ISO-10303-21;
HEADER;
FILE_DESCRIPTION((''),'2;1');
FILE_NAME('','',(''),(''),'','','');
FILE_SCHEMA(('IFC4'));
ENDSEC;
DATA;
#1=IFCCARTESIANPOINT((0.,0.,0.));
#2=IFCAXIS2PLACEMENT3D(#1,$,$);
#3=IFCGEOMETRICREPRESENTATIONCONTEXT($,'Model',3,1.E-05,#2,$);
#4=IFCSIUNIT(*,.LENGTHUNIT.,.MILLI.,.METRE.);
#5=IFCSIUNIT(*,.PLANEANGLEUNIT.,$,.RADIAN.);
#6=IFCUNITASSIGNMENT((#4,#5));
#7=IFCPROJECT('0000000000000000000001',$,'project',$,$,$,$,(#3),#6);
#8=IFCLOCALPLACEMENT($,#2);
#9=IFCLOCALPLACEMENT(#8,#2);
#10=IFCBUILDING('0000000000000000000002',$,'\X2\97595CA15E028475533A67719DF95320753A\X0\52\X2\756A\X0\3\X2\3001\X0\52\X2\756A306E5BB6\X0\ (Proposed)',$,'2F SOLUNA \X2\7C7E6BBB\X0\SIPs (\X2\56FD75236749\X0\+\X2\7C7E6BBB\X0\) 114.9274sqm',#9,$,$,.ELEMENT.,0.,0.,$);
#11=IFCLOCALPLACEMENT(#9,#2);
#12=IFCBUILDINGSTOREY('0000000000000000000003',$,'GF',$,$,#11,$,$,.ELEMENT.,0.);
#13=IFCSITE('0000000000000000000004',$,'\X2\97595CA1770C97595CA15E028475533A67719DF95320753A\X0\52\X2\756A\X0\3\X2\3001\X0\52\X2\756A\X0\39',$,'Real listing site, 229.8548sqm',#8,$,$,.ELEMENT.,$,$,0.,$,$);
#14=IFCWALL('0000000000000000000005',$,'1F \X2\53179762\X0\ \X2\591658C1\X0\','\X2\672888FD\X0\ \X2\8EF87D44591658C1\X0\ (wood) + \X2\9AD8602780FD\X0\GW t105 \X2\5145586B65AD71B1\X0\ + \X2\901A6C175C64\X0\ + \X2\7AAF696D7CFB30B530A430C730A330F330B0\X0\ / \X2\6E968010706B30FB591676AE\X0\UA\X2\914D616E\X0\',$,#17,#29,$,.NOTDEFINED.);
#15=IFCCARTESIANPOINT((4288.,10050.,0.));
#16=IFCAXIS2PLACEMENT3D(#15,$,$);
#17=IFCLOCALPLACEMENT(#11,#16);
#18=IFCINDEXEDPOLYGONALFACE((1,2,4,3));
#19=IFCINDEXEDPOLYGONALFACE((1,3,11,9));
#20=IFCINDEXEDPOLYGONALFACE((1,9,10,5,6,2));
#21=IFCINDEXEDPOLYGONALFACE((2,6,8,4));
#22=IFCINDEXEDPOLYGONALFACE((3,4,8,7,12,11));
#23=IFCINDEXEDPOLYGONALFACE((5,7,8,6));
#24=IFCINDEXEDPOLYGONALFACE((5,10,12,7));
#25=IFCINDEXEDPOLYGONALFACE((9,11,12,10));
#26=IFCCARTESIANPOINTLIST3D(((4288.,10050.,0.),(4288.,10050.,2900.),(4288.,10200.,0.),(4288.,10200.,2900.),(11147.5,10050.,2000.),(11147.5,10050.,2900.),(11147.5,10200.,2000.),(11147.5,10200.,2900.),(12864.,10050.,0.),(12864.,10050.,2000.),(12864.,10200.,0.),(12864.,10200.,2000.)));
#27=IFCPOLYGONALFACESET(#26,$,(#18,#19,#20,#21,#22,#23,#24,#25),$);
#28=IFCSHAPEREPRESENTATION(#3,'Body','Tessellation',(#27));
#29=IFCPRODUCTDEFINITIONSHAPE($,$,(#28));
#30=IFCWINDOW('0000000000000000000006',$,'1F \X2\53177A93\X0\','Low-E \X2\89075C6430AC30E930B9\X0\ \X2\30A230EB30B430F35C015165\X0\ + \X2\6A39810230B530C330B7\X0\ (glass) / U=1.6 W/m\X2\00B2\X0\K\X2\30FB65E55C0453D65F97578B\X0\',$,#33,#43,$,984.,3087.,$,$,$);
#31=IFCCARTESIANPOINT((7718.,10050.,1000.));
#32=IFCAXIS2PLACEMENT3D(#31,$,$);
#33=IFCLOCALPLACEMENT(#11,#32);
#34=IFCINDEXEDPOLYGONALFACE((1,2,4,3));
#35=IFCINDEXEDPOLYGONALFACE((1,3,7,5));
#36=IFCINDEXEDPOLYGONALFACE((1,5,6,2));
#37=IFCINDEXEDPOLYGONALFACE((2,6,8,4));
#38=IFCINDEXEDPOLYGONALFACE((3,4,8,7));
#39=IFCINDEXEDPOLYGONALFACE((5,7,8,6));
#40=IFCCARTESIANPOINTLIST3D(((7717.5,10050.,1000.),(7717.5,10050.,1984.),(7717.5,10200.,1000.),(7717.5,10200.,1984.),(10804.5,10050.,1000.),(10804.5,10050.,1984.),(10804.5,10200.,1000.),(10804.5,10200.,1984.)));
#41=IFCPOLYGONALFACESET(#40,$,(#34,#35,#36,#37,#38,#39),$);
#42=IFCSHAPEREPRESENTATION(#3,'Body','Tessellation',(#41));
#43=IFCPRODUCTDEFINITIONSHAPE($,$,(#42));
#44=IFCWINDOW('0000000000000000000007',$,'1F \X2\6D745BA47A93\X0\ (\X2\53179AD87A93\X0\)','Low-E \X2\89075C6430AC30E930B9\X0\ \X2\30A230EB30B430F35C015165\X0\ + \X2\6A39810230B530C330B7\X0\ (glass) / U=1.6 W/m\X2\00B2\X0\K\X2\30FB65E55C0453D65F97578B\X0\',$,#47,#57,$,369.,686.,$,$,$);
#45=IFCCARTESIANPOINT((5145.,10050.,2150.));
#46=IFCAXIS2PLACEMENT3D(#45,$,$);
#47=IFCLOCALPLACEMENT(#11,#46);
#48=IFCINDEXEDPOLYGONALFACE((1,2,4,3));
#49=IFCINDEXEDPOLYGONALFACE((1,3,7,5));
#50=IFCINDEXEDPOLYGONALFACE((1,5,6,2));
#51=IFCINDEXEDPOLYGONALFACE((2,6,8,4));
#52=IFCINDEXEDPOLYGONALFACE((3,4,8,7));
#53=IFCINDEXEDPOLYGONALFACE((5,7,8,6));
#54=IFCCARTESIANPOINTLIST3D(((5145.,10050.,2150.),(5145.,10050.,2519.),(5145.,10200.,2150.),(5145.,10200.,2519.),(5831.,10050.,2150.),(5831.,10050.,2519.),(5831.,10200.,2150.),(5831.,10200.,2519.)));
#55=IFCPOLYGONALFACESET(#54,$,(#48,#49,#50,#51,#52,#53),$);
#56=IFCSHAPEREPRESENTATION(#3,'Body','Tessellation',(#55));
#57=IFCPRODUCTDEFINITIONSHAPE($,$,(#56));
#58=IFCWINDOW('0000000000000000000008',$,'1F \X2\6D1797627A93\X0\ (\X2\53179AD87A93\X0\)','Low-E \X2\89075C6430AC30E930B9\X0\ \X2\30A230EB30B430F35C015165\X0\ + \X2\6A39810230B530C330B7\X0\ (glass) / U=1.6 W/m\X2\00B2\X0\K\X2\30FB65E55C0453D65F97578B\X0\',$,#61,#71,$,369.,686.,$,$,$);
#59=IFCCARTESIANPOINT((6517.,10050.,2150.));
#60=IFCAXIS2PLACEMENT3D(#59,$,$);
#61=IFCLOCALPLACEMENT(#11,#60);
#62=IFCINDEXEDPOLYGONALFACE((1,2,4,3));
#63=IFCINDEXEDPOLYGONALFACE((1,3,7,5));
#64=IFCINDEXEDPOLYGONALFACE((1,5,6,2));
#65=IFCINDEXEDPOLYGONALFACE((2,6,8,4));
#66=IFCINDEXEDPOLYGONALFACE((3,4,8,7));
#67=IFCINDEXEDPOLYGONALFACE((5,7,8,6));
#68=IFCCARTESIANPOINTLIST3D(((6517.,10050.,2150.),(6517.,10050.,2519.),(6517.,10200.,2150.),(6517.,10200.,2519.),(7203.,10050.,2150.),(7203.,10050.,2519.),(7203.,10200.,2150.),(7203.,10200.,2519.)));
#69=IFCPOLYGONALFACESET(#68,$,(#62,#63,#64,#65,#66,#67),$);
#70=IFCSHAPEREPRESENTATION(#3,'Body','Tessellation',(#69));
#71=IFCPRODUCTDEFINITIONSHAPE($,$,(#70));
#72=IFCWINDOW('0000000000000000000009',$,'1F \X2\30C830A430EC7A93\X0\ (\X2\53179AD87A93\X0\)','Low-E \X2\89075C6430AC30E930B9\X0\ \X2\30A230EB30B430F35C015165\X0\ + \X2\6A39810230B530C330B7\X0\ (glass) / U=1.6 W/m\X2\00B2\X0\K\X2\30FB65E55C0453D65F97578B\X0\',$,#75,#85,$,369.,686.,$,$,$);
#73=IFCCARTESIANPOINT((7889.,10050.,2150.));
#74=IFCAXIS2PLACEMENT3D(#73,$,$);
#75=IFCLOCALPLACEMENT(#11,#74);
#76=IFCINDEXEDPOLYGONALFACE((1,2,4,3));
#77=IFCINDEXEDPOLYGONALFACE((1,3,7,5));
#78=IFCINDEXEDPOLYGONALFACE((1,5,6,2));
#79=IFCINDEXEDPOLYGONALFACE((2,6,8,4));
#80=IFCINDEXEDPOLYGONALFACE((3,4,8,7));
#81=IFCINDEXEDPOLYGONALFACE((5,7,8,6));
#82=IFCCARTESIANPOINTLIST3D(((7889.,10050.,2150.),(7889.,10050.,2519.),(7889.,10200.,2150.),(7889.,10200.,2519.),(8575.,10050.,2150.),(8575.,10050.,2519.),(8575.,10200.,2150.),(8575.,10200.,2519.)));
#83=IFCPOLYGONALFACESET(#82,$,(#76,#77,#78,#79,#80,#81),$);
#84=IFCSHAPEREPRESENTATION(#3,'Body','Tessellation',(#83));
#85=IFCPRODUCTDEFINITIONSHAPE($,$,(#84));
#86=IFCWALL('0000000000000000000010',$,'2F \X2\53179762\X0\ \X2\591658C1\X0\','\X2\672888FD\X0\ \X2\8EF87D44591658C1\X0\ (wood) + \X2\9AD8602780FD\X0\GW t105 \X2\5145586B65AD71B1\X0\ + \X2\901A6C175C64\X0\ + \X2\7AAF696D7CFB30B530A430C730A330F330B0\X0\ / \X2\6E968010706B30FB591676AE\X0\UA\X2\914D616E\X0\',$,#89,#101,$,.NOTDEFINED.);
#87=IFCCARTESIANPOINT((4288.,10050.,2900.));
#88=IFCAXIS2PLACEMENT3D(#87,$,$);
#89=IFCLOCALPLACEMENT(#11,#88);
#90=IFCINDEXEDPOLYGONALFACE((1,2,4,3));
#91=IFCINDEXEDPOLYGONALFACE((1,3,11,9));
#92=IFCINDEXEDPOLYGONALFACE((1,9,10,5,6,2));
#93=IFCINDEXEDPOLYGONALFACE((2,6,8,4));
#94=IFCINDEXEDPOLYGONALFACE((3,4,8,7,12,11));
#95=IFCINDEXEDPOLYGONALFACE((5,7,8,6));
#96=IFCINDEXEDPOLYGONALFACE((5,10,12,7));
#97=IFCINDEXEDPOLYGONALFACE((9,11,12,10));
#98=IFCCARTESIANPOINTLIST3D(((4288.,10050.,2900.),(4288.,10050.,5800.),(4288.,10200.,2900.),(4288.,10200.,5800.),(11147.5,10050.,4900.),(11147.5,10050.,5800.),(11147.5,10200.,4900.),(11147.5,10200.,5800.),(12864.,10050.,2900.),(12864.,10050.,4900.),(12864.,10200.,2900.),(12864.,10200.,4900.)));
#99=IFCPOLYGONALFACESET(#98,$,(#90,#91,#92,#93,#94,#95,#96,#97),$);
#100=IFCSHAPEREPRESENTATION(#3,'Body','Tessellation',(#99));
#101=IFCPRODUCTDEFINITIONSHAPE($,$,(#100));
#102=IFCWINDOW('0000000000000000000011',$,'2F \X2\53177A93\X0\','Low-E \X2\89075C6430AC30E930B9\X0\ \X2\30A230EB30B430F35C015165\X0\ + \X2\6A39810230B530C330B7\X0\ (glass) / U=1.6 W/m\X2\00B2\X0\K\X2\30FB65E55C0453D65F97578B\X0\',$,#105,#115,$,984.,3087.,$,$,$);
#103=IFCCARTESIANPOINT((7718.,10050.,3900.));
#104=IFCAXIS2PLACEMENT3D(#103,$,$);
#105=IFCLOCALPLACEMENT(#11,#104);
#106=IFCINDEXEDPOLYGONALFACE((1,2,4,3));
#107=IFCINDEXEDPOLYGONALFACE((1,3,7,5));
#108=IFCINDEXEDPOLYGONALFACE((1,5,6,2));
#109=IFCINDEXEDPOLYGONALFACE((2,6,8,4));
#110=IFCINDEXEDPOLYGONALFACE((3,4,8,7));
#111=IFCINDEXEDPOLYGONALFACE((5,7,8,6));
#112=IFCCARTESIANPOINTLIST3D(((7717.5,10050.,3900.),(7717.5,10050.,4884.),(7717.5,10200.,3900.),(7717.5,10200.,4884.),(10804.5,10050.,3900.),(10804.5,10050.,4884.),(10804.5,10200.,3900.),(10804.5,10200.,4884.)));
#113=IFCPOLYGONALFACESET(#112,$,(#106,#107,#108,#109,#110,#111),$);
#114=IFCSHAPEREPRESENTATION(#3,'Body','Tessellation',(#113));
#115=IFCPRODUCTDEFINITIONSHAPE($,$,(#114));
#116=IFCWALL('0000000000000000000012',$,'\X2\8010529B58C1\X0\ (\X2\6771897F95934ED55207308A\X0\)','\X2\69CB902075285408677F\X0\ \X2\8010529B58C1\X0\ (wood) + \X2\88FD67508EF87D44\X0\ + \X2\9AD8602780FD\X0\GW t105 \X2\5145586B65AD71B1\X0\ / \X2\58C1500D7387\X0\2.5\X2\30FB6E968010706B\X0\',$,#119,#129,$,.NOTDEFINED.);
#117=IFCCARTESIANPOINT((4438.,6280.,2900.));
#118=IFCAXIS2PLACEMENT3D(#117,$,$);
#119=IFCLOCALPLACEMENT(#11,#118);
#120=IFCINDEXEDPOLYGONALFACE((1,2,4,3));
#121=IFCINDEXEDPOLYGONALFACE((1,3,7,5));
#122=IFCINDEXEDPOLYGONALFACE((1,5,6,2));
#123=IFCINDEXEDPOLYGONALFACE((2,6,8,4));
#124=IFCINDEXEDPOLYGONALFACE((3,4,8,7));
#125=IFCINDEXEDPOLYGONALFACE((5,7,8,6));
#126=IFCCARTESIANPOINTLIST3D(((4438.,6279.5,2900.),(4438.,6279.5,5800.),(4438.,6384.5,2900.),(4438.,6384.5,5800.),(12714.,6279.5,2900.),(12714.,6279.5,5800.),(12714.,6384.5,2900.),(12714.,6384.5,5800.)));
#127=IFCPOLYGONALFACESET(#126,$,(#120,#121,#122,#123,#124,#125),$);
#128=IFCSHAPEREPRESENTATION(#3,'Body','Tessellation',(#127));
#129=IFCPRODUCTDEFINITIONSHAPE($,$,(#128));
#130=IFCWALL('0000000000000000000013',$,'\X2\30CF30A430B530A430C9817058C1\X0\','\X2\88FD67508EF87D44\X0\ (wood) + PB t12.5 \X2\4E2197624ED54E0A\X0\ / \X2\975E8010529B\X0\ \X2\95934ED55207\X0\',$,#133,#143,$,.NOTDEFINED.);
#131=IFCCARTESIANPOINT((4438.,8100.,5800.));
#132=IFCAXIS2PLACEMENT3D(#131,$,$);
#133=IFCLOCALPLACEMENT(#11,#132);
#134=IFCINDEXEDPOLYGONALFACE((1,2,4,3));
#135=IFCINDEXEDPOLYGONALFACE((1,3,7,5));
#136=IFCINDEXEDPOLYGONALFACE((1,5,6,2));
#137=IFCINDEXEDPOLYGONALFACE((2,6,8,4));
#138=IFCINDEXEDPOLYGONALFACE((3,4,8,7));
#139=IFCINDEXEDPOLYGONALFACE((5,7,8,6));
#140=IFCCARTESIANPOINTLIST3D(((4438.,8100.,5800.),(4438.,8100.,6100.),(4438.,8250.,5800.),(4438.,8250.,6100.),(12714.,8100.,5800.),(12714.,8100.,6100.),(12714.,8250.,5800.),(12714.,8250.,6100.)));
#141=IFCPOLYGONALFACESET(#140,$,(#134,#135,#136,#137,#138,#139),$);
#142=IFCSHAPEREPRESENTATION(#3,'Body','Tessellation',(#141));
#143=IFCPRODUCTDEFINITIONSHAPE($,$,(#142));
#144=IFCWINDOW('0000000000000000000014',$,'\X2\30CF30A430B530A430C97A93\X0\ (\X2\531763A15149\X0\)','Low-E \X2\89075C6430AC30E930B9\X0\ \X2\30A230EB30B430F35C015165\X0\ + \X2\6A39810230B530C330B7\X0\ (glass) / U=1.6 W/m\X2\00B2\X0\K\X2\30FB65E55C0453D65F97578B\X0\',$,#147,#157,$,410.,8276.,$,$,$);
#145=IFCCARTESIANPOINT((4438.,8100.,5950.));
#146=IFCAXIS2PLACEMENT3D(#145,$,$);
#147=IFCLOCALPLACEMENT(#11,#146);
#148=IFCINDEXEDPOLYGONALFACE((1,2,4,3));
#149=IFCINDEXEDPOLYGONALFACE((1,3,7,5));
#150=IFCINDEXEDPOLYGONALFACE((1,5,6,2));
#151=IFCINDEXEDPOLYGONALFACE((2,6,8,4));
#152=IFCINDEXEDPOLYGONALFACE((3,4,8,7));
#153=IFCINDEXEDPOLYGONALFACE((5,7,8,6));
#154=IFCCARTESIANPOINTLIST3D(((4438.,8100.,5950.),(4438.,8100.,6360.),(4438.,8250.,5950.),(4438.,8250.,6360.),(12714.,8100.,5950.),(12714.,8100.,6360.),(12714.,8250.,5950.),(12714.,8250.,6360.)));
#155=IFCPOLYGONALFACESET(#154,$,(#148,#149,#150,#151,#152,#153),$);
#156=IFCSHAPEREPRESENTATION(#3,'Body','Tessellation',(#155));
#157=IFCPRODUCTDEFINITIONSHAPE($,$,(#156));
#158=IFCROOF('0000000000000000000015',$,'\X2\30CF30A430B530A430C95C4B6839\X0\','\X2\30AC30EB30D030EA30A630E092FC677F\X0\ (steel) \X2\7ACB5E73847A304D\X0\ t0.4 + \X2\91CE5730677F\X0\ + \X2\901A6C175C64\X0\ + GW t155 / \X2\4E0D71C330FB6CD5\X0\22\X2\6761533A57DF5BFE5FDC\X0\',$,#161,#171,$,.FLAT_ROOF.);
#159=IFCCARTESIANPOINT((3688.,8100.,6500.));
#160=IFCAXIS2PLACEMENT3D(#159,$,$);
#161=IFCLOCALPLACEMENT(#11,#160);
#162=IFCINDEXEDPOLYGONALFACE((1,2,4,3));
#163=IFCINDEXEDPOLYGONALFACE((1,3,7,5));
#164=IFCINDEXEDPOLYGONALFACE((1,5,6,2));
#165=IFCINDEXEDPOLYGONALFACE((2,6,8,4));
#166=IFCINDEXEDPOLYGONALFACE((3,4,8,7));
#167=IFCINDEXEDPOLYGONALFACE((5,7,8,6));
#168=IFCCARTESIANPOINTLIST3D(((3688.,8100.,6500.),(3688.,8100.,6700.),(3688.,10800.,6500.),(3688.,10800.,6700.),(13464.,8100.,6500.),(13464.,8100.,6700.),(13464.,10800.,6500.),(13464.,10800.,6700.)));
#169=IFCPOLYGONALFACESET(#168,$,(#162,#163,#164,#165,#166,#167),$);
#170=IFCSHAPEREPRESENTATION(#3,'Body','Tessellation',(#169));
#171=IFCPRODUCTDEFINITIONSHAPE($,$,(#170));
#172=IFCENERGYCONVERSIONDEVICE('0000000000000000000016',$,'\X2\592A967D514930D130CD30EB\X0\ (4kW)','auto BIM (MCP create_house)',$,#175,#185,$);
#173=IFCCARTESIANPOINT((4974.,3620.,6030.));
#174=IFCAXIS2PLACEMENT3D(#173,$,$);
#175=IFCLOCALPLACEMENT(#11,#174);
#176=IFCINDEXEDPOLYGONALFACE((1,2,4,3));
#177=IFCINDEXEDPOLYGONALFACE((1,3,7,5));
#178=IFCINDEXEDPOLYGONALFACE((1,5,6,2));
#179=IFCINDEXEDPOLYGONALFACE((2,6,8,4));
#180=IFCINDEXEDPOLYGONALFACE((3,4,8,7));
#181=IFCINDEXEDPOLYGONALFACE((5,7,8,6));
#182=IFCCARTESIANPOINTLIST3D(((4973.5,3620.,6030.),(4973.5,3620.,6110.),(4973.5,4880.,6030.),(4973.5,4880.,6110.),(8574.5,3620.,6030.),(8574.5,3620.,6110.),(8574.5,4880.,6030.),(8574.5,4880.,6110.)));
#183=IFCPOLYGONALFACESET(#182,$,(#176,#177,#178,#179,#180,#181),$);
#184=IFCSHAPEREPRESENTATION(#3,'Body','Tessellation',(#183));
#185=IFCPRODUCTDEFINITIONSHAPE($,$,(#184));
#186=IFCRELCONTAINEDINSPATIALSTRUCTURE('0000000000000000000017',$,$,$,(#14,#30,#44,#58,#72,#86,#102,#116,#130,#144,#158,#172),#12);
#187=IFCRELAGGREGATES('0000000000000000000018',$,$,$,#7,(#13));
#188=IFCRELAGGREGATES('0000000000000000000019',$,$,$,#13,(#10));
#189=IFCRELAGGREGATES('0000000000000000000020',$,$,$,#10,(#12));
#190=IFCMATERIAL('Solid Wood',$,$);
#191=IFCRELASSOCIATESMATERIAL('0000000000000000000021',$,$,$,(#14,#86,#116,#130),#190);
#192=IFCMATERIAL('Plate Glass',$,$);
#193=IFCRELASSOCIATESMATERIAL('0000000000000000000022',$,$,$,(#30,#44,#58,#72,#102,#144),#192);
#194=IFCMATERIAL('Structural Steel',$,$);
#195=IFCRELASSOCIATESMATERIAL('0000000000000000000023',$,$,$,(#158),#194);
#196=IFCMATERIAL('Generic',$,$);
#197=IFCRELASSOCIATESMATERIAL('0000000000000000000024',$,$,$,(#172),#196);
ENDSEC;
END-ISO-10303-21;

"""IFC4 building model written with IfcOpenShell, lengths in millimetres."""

from ifc_helpers import new_model, si_unit, frame, frame_2d, origin, place, context, project, spatial, rectangle, extrude, material, element, fill, save


model = new_model("IFC4")

# Units and contexts
model_context = context("Model", 3, precision=1e-05, world=origin())
ifc_project = project(units=[si_unit("LENGTHUNIT", "METRE", prefix="MILLI"), si_unit("PLANEANGLEUNIT", "RADIAN")], contexts=[model_context])

# Site, building, storey
site_placement = place(None, origin())
site = spatial("IfcSite", under=ifc_project, at=site_placement, Name="静岡県静岡市葵区東鷹匠町52番3、52番39", ObjectType="Real listing site, 229.8548sqm", CompositionType="ELEMENT", RefElevation=0.0)
building_placement = place(site_placement, origin())
building = spatial("IfcBuilding", under=site, at=building_placement, Name="静岡市葵区東鷹匠町52番3、52番の家 (Proposed)", ObjectType="2F SOLUNA 籾殻SIPs (国産杉+籾殻) 114.9274sqm", CompositionType="ELEMENT", ElevationOfRefHeight=0.0, ElevationOfTerrain=0.0)
storey_placement = place(building_placement, origin())
storey = spatial("IfcBuildingStorey", under=building, at=storey_placement, Name="GF", CompositionType="ELEMENT", Elevation=0.0)

# Wall, openings, windows
ifc_material_1 = material(Name="Solid Wood")
wall_1_placement = place(storey_placement, frame((4288.0, 10050.0, 0.0)))
wall_1 = element("IfcWall", 1, at=wall_1_placement, inside=storey, material=ifc_material_1, Name="1F 北面 外壁", Description="木製 軸組外壁 (wood) + 高性能GW t105 充填断熱 + 通気層 + 窯業系サイディング / 準耐火・外皮UA配慮", PredefinedType="NOTDEFINED", context=model_context, shape_type="SweptSolid", body=[
    extrude(rectangle(XDim=8576.0, YDim=150.0, at=frame_2d((4288.0, 75.0))), frame((4288.0, 10050.0, 0.0)), (0.0, 0.0, 1.0), 2900.0),
])
opening_1_placement = place(storey_placement, frame((7718.0, 10050.0, 1000.0)))
opening_1 = element("IfcOpeningElement", 2, at=opening_1_placement, cuts=wall_1, PredefinedType="NOTDEFINED", context=model_context, shape_type="SweptSolid", body=[
    extrude(rectangle(XDim=3087.0, YDim=150.0, at=frame_2d((1543.0, 75.0))), frame((7718.0, 10050.0, 1000.0)), (0.0, 0.0, 1.0), 984.0),
])
opening_2_placement = place(storey_placement, frame((5145.0, 10050.0, 2150.0)))
opening_2 = element("IfcOpeningElement", 3, at=opening_2_placement, cuts=wall_1, PredefinedType="NOTDEFINED", context=model_context, shape_type="SweptSolid", body=[
    extrude(rectangle(XDim=686.0, YDim=150.0, at=frame_2d((343.0, 75.0))), frame((5145.0, 10050.0, 2150.0)), (0.0, 0.0, 1.0), 369.0),
])
opening_3_placement = place(storey_placement, frame((6517.0, 10050.0, 2150.0)))
opening_3 = element("IfcOpeningElement", 4, at=opening_3_placement, cuts=wall_1, PredefinedType="NOTDEFINED", context=model_context, shape_type="SweptSolid", body=[
    extrude(rectangle(XDim=686.0, YDim=150.0, at=frame_2d((343.0, 75.0))), frame((6517.0, 10050.0, 2150.0)), (0.0, 0.0, 1.0), 369.0),
])
opening_4_placement = place(storey_placement, frame((7889.0, 10050.0, 2150.0)))
opening_4 = element("IfcOpeningElement", 5, at=opening_4_placement, cuts=wall_1, PredefinedType="NOTDEFINED", context=model_context, shape_type="SweptSolid", body=[
    extrude(rectangle(XDim=686.0, YDim=150.0, at=frame_2d((343.0, 75.0))), frame((7889.0, 10050.0, 2150.0)), (0.0, 0.0, 1.0), 369.0),
])
ifc_material_2 = material(Name="Plate Glass")
window_1_placement = place(storey_placement, frame((7718.0, 10050.0, 1000.0)))
window_1 = element("IfcWindow", 6, at=window_1_placement, inside=storey, material=ifc_material_2, Name="1F 北窓", Description="Low-E 複層ガラス アルゴン封入 + 樹脂サッシ (glass) / U=1.6 W/m²K・日射取得型", OverallHeight=984.0, OverallWidth=3087.0, context=model_context, shape_type="SweptSolid", body=[
    extrude(rectangle(XDim=3087.0, YDim=150.0, at=frame_2d((1543.0, 75.0))), frame((7718.0, 10050.0, 1000.0)), (0.0, 0.0, 1.0), 984.0),
])
fill(opening_1, window_1)
window_2_placement = place(storey_placement, frame((5145.0, 10050.0, 2150.0)))
window_2 = element("IfcWindow", 7, at=window_2_placement, inside=storey, material=ifc_material_2, Name="1F 浴室窓 (北高窓)", Description="Low-E 複層ガラス アルゴン封入 + 樹脂サッシ (glass) / U=1.6 W/m²K・日射取得型", OverallHeight=369.0, OverallWidth=686.0, context=model_context, shape_type="SweptSolid", body=[
    extrude(rectangle(XDim=686.0, YDim=150.0, at=frame_2d((343.0, 75.0))), frame((5145.0, 10050.0, 2150.0)), (0.0, 0.0, 1.0), 369.0),
])
fill(opening_2, window_2)
window_3_placement = place(storey_placement, frame((6517.0, 10050.0, 2150.0)))
window_3 = element("IfcWindow", 8, at=window_3_placement, inside=storey, material=ifc_material_2, Name="1F 洗面窓 (北高窓)", Description="Low-E 複層ガラス アルゴン封入 + 樹脂サッシ (glass) / U=1.6 W/m²K・日射取得型", OverallHeight=369.0, OverallWidth=686.0, context=model_context, shape_type="SweptSolid", body=[
    extrude(rectangle(XDim=686.0, YDim=150.0, at=frame_2d((343.0, 75.0))), frame((6517.0, 10050.0, 2150.0)), (0.0, 0.0, 1.0), 369.0),
])
fill(opening_3, window_3)
window_4_placement = place(storey_placement, frame((7889.0, 10050.0, 2150.0)))
window_4 = element("IfcWindow", 9, at=window_4_placement, inside=storey, material=ifc_material_2, Name="1F トイレ窓 (北高窓)", Description="Low-E 複層ガラス アルゴン封入 + 樹脂サッシ (glass) / U=1.6 W/m²K・日射取得型", OverallHeight=369.0, OverallWidth=686.0, context=model_context, shape_type="SweptSolid", body=[
    extrude(rectangle(XDim=686.0, YDim=150.0, at=frame_2d((343.0, 75.0))), frame((7889.0, 10050.0, 2150.0)), (0.0, 0.0, 1.0), 369.0),
])
fill(opening_4, window_4)

# Wall, opening, window
wall_2_placement = place(storey_placement, frame((4288.0, 10050.0, 2900.0)))
wall_2 = element("IfcWall", 10, at=wall_2_placement, inside=storey, material=ifc_material_1, Name="2F 北面 外壁", Description="木製 軸組外壁 (wood) + 高性能GW t105 充填断熱 + 通気層 + 窯業系サイディング / 準耐火・外皮UA配慮", PredefinedType="NOTDEFINED", context=model_context, shape_type="SweptSolid", body=[
    extrude(rectangle(XDim=8576.0, YDim=150.0, at=frame_2d((4288.0, 75.0))), frame((4288.0, 10050.0, 2900.0)), (0.0, 0.0, 1.0), 2900.0),
])
opening_5_placement = place(storey_placement, frame((7718.0, 10050.0, 3900.0)))
opening_5 = element("IfcOpeningElement", 11, at=opening_5_placement, cuts=wall_2, PredefinedType="NOTDEFINED", context=model_context, shape_type="SweptSolid", body=[
    extrude(rectangle(XDim=3087.0, YDim=150.0, at=frame_2d((1543.0, 75.0))), frame((7718.0, 10050.0, 3900.0)), (0.0, 0.0, 1.0), 984.0),
])
window_5_placement = place(storey_placement, frame((7718.0, 10050.0, 3900.0)))
window_5 = element("IfcWindow", 12, at=window_5_placement, inside=storey, material=ifc_material_2, Name="2F 北窓", Description="Low-E 複層ガラス アルゴン封入 + 樹脂サッシ (glass) / U=1.6 W/m²K・日射取得型", OverallHeight=984.0, OverallWidth=3087.0, context=model_context, shape_type="SweptSolid", body=[
    extrude(rectangle(XDim=3087.0, YDim=150.0, at=frame_2d((1543.0, 75.0))), frame((7718.0, 10050.0, 3900.0)), (0.0, 0.0, 1.0), 984.0),
])
fill(opening_5, window_5)

# Wall
wall_3_placement = place(storey_placement, frame((4438.0, 6280.0, 2900.0)))
element("IfcWall", 13, at=wall_3_placement, inside=storey, material=ifc_material_1, Name="耐力壁 (東西間仕切り)", Description="構造用合板 耐力壁 (wood) + 製材軸組 + 高性能GW t105 充填断熱 / 壁倍率2.5・準耐火", PredefinedType="NOTDEFINED", context=model_context, shape_type="SweptSolid", body=[
    extrude(rectangle(XDim=8276.0, YDim=105.0, at=frame_2d((4138.0, 52.0))), frame((4438.0, 6280.0, 2900.0)), (0.0, 0.0, 1.0), 2900.0),
])

# Wall, opening, window
wall_4_placement = place(storey_placement, frame((4438.0, 8100.0, 5800.0)))
wall_4 = element("IfcWall", 14, at=wall_4_placement, inside=storey, material=ifc_material_1, Name="ハイサイド腰壁", Description="製材軸組 (wood) + PB t12.5 両面仕上 / 非耐力 間仕切", PredefinedType="NOTDEFINED", context=model_context, shape_type="SweptSolid", body=[
    extrude(rectangle(XDim=8276.0, YDim=150.0, at=frame_2d((4138.0, 75.0))), frame((4438.0, 8100.0, 5800.0)), (0.0, 0.0, 1.0), 700.0),
])
opening_6_placement = place(storey_placement, frame((4438.0, 8100.0, 5950.0)))
opening_6 = element("IfcOpeningElement", 15, at=opening_6_placement, cuts=wall_4, PredefinedType="NOTDEFINED", context=model_context, shape_type="SweptSolid", body=[
    extrude(rectangle(XDim=8276.0, YDim=150.0, at=frame_2d((4138.0, 75.0))), frame((4438.0, 8100.0, 5950.0)), (0.0, 0.0, 1.0), 410.0),
])
window_6_placement = place(storey_placement, frame((4438.0, 8100.0, 5950.0)))
window_6 = element("IfcWindow", 16, at=window_6_placement, inside=storey, material=ifc_material_2, Name="ハイサイド窓 (北採光)", Description="Low-E 複層ガラス アルゴン封入 + 樹脂サッシ (glass) / U=1.6 W/m²K・日射取得型", OverallHeight=410.0, OverallWidth=8276.0, context=model_context, shape_type="SweptSolid", body=[
    extrude(rectangle(XDim=8276.0, YDim=150.0, at=frame_2d((4138.0, 75.0))), frame((4438.0, 8100.0, 5950.0)), (0.0, 0.0, 1.0), 410.0),
])
fill(opening_6, window_6)

# Roof
ifc_material_3 = material(Name="Structural Steel")
roof_placement = place(storey_placement, frame((3688.0, 8100.0, 6500.0)))
element("IfcRoof", 17, at=roof_placement, inside=storey, material=ifc_material_3, Name="ハイサイド屋根", Description="ガルバリウム鋼板 (steel) 立平葺き t0.4 + 野地板 + 通気層 + GW t155 / 不燃・法22条区域対応", PredefinedType="FLAT_ROOF", context=model_context, shape_type="SweptSolid", body=[
    extrude(rectangle(XDim=9776.0, YDim=2700.0, at=frame_2d((4888.0, 1350.0))), frame((3688.0, 8100.0, 6500.0)), (0.0, 0.0, 1.0), 200.0),
])

# Energy conversion device
ifc_material_4 = material(Name="Generic")
energy_conversion_device_placement = place(storey_placement, frame((4974.0, 3620.0, 6030.0)))
element("IfcEnergyConversionDevice", 18, at=energy_conversion_device_placement, inside=storey, material=ifc_material_4, Name="太陽光パネル (4kW)", Description="auto BIM (MCP create_house)", context=model_context, shape_type="SweptSolid", body=[
    extrude(rectangle(XDim=3601.0, YDim=1260.0, at=frame_2d((1800.0, 630.0))), frame((4974.0, 3620.0, 6030.0)), (0.0, 0.0, 1.0), 80.0),
])

save(model, "model.ifc")
